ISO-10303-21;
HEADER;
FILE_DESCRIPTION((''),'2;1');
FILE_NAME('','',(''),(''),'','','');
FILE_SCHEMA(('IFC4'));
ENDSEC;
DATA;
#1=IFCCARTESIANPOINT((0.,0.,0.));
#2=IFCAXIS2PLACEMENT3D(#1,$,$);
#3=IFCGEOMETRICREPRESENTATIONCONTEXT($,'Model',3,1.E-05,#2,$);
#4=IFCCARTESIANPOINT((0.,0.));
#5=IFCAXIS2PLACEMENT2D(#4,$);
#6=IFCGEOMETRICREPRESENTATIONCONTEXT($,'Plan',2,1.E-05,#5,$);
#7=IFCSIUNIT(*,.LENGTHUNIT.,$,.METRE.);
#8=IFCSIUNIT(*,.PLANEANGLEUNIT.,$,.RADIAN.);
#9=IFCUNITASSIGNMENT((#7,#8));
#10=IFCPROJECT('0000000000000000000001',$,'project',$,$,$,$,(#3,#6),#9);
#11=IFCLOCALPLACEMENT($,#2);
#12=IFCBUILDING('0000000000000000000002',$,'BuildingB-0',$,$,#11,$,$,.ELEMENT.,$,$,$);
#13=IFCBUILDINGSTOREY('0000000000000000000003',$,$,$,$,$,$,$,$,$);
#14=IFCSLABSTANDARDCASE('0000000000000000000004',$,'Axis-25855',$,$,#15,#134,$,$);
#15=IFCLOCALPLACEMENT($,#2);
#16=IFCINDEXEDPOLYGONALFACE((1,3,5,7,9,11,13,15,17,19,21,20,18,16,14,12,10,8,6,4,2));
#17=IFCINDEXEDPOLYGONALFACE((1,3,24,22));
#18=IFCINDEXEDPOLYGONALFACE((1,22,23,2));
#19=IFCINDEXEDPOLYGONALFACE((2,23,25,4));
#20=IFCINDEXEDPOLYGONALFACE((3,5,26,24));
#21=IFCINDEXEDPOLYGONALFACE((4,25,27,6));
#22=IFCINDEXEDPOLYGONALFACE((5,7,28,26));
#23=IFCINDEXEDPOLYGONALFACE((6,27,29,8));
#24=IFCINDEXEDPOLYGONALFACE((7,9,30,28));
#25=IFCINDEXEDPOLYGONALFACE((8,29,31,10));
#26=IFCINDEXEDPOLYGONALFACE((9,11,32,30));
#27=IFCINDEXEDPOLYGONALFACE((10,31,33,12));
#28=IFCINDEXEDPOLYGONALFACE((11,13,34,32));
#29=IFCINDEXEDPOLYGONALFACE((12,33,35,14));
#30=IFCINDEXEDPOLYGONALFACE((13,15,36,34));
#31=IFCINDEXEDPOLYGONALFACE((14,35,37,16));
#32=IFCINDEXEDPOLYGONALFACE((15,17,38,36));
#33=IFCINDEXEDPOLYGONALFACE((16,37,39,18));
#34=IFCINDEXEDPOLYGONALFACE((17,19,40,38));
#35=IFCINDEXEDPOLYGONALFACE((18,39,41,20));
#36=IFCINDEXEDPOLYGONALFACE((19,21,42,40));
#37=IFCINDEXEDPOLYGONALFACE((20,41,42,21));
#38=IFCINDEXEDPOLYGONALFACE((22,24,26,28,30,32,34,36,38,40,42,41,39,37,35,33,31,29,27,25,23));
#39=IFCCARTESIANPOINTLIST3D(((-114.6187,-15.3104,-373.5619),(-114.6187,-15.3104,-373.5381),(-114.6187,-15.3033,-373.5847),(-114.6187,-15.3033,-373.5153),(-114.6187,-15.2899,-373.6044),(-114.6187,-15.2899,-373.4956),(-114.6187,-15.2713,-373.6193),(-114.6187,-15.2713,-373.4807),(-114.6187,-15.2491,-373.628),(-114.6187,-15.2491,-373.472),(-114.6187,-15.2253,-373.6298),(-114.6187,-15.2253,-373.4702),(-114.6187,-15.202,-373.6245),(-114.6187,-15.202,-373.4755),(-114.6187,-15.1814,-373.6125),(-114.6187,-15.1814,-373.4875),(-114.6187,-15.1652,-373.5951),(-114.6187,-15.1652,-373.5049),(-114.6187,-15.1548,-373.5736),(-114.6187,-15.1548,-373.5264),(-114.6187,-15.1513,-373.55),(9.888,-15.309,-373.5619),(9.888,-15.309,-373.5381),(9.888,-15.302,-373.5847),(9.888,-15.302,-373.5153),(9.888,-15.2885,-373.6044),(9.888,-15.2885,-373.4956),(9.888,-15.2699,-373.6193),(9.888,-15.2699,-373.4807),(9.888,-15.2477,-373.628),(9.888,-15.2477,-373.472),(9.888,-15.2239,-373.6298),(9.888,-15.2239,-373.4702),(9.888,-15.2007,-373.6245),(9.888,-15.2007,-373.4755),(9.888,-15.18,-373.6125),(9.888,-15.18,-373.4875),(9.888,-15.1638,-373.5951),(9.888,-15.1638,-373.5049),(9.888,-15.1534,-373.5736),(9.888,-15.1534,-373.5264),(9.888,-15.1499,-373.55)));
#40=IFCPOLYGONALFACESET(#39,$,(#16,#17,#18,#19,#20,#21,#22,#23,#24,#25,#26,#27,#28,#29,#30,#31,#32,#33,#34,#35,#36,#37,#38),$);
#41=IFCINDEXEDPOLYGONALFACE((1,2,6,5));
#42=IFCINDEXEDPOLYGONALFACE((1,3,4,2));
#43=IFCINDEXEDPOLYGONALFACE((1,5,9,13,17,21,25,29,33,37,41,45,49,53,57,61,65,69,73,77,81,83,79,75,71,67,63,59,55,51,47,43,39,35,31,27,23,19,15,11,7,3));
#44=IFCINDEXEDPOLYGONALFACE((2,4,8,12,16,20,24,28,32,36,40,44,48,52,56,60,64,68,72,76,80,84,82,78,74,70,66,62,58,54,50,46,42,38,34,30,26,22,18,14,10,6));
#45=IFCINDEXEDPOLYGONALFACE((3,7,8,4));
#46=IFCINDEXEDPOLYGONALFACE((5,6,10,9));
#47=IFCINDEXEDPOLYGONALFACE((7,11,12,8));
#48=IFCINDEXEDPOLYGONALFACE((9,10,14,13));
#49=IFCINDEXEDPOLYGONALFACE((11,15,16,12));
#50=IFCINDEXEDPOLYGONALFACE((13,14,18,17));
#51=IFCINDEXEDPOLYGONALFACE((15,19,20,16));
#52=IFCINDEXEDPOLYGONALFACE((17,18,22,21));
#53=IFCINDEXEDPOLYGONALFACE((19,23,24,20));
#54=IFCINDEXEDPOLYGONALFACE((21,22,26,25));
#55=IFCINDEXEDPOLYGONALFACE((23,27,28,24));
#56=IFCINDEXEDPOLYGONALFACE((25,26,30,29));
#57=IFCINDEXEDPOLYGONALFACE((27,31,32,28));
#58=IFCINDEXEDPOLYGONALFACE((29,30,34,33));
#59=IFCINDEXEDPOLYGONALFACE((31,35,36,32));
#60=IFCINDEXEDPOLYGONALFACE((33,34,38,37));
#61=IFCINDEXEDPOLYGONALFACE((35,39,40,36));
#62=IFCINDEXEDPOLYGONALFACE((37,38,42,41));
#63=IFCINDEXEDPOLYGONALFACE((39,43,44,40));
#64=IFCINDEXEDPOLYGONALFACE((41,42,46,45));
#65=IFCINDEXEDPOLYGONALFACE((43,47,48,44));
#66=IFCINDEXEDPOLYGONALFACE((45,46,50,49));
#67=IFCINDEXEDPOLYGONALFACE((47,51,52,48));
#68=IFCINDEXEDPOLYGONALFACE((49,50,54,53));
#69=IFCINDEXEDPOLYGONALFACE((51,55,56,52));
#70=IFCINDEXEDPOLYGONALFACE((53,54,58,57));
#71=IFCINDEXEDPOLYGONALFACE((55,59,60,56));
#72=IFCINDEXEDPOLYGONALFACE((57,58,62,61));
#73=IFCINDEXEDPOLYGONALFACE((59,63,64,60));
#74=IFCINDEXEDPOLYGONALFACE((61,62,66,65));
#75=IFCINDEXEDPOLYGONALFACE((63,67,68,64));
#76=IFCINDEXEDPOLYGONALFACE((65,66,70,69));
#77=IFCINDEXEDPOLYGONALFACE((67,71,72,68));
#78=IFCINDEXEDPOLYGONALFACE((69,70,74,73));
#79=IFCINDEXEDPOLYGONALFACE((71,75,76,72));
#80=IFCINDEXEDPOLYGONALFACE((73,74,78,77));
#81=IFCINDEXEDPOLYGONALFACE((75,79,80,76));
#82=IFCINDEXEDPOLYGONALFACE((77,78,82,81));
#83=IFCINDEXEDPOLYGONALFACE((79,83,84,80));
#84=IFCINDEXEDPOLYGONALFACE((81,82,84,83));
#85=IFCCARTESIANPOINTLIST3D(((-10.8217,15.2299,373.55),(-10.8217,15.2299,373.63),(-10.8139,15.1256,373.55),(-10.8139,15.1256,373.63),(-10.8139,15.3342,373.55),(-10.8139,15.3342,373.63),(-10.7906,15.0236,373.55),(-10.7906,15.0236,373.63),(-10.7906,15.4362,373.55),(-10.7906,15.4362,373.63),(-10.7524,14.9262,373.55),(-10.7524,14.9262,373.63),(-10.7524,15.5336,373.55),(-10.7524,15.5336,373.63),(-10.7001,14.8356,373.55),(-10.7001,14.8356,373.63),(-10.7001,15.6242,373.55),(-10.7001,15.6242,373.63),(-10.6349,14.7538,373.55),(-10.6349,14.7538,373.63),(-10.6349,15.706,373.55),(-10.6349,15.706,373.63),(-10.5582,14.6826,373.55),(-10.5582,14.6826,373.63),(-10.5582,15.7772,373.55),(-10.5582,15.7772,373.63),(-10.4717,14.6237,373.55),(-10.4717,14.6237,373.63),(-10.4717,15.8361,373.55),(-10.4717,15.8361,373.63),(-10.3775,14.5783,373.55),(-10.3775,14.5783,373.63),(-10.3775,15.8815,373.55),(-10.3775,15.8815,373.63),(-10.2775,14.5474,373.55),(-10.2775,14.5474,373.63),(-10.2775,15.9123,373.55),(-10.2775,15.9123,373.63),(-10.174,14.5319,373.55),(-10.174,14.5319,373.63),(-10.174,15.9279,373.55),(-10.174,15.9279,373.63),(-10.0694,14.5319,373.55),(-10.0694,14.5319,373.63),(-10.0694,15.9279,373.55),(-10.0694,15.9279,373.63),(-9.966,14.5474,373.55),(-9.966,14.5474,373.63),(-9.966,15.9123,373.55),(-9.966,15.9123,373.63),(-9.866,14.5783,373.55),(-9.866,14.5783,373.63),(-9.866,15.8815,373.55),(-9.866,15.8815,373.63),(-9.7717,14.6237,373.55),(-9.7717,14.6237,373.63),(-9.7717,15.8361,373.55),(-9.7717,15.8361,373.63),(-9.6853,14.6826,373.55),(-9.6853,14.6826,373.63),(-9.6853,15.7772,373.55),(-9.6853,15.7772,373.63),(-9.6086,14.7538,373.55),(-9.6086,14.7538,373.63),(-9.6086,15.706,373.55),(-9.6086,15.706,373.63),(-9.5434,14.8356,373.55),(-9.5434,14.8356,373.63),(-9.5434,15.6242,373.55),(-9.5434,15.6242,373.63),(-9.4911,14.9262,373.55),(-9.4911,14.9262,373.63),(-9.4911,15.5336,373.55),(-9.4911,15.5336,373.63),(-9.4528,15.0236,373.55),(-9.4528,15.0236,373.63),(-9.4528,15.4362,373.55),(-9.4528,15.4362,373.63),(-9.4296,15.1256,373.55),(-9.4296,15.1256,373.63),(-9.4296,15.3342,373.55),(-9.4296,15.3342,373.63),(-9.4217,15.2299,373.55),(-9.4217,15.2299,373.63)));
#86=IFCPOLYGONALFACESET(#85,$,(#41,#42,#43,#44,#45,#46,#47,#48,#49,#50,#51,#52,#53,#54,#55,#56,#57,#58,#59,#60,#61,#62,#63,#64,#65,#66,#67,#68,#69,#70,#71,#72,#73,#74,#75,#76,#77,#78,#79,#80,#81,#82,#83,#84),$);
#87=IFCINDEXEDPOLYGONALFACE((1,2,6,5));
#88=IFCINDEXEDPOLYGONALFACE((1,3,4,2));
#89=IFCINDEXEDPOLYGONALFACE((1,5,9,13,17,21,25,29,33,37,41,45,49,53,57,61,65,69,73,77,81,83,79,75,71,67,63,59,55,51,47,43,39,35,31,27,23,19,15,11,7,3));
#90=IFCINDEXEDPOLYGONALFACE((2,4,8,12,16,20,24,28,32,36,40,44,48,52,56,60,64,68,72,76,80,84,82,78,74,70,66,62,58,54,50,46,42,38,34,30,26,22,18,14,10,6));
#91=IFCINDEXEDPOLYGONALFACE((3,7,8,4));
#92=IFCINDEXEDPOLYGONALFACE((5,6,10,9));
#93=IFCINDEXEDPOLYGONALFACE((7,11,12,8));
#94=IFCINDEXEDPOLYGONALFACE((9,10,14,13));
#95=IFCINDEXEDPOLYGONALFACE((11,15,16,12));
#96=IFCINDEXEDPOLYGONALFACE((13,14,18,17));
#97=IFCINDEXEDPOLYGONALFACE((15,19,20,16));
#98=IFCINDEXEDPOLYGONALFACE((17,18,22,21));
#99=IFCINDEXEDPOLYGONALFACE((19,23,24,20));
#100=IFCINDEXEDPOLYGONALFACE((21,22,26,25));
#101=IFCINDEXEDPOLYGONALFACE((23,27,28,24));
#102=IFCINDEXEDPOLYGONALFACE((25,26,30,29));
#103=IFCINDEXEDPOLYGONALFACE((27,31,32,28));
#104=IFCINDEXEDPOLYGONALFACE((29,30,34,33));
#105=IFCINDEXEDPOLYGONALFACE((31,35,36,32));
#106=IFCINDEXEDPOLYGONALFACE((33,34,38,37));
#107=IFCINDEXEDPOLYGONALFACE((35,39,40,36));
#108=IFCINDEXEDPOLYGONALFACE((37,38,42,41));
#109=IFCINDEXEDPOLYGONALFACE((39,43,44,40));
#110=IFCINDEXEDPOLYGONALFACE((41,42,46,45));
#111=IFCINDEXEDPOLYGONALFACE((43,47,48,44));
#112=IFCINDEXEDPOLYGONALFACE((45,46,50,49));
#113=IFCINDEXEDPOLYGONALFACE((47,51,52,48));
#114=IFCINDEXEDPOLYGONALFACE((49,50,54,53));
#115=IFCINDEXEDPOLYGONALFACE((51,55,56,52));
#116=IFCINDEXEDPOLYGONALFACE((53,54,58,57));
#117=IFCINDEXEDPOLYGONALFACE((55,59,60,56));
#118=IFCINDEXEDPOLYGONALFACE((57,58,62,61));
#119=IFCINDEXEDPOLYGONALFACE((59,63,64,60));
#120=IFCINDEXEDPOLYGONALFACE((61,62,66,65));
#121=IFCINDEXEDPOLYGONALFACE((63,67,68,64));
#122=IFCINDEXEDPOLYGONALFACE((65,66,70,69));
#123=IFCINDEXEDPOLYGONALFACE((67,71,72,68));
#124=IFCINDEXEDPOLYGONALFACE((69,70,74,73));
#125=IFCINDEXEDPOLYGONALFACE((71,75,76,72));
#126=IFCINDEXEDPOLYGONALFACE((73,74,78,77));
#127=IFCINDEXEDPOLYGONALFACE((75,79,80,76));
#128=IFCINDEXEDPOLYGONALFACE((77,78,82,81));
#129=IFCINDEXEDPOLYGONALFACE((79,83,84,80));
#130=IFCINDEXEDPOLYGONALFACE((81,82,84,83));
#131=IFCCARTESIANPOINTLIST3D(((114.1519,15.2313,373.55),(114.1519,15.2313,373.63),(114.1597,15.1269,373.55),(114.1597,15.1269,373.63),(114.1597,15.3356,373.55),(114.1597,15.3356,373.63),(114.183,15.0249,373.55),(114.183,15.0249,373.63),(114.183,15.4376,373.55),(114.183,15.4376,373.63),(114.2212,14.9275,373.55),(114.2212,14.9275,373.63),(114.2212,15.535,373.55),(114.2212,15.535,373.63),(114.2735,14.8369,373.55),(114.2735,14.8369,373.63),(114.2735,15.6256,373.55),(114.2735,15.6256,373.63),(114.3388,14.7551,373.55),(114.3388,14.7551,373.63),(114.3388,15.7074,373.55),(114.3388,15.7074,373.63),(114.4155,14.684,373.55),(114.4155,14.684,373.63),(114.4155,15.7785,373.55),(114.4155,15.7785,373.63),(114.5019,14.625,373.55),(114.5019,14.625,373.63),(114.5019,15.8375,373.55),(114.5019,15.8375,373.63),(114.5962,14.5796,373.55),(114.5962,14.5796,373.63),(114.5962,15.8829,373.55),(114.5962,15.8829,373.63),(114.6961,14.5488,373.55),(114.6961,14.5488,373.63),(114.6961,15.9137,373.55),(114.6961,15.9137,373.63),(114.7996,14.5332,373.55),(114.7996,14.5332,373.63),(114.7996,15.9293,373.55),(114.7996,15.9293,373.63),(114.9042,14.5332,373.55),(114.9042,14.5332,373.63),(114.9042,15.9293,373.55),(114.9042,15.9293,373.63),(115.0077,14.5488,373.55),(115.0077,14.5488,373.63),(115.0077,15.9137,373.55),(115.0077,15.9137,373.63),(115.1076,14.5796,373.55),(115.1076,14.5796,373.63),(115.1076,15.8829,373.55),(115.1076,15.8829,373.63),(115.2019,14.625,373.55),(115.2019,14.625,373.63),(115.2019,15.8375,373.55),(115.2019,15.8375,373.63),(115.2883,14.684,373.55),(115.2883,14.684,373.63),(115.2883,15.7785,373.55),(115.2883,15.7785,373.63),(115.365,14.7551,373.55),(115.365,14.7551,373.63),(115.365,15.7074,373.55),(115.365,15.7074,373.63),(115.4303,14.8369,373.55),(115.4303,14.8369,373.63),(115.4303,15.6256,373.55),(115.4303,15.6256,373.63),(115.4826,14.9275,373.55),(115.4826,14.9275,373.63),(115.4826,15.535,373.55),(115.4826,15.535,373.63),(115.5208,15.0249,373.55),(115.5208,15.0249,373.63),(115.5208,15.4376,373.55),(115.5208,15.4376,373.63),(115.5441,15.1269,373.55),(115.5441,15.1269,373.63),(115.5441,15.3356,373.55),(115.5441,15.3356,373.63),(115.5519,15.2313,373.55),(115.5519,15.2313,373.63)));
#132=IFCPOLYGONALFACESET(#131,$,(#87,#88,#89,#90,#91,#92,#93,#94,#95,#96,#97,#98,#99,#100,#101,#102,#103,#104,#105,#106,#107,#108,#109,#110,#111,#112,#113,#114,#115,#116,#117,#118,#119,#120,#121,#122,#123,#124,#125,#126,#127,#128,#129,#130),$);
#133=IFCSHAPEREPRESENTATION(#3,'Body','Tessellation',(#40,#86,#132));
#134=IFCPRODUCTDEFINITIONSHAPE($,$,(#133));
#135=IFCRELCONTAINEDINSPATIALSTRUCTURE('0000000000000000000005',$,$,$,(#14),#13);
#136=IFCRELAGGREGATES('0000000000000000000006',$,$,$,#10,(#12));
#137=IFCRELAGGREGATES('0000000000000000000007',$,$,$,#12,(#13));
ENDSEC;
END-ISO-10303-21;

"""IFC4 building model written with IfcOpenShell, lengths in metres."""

from ifc_helpers import new_model, entity, si_unit, frame, origin, origin_2d, place, context, project, spatial, circle, extrude, element, save


model = new_model("IFC4")

# Units and contexts
model_context = context("Model", 3, precision=1e-05, world=origin())
plan_context = context("Plan", 2, precision=1e-05, world=origin_2d())
ifc_project = project(units=[si_unit("LENGTHUNIT", "METRE"), si_unit("PLANEANGLEUNIT", "RADIAN")], contexts=[model_context, plan_context])

# Building, storey
building_placement = place(None, origin())
building = spatial("IfcBuilding", under=ifc_project, at=building_placement, Name="BuildingB-0", CompositionType="ELEMENT")
storey = spatial("IfcBuildingStorey", under=building)

# Slab
element("IfcSlabStandardCase", 1, inside=storey, Name="Axis-25855", context=model_context, shape_type="AdvancedSweptSolid", body=[
    entity("IfcSurfaceCurveSweptAreaSolid", entity("IfcCircleProfileDef", "AREA", None, None, 0.08), None, entity("IfcPolyline", [entity("IfcCartesianPoint", [-9.888, 15.2299, 373.55]), entity("IfcCartesianPoint", [114.6187, 15.2313, 373.55])]), None, None, entity("IfcPlane", entity("IfcAxis2Placement3D", entity("IfcCartesianPoint", [-9.888, 15.2299, 373.55]), entity("IfcDirection", [0.0, 0.0, 1.0]), entity("IfcDirection", [1.0, 0.0, 0.0])))),
    extrude(circle(Radius=0.7), frame((-10.1217, 15.2299, 373.55)), (0.0, 0.0, 1.0), 0.08),
    extrude(circle(Radius=0.7), frame((114.8519, 15.2313, 373.55)), (0.0, 0.0, 1.0), 0.08),
])

save(model, "model.ifc")
